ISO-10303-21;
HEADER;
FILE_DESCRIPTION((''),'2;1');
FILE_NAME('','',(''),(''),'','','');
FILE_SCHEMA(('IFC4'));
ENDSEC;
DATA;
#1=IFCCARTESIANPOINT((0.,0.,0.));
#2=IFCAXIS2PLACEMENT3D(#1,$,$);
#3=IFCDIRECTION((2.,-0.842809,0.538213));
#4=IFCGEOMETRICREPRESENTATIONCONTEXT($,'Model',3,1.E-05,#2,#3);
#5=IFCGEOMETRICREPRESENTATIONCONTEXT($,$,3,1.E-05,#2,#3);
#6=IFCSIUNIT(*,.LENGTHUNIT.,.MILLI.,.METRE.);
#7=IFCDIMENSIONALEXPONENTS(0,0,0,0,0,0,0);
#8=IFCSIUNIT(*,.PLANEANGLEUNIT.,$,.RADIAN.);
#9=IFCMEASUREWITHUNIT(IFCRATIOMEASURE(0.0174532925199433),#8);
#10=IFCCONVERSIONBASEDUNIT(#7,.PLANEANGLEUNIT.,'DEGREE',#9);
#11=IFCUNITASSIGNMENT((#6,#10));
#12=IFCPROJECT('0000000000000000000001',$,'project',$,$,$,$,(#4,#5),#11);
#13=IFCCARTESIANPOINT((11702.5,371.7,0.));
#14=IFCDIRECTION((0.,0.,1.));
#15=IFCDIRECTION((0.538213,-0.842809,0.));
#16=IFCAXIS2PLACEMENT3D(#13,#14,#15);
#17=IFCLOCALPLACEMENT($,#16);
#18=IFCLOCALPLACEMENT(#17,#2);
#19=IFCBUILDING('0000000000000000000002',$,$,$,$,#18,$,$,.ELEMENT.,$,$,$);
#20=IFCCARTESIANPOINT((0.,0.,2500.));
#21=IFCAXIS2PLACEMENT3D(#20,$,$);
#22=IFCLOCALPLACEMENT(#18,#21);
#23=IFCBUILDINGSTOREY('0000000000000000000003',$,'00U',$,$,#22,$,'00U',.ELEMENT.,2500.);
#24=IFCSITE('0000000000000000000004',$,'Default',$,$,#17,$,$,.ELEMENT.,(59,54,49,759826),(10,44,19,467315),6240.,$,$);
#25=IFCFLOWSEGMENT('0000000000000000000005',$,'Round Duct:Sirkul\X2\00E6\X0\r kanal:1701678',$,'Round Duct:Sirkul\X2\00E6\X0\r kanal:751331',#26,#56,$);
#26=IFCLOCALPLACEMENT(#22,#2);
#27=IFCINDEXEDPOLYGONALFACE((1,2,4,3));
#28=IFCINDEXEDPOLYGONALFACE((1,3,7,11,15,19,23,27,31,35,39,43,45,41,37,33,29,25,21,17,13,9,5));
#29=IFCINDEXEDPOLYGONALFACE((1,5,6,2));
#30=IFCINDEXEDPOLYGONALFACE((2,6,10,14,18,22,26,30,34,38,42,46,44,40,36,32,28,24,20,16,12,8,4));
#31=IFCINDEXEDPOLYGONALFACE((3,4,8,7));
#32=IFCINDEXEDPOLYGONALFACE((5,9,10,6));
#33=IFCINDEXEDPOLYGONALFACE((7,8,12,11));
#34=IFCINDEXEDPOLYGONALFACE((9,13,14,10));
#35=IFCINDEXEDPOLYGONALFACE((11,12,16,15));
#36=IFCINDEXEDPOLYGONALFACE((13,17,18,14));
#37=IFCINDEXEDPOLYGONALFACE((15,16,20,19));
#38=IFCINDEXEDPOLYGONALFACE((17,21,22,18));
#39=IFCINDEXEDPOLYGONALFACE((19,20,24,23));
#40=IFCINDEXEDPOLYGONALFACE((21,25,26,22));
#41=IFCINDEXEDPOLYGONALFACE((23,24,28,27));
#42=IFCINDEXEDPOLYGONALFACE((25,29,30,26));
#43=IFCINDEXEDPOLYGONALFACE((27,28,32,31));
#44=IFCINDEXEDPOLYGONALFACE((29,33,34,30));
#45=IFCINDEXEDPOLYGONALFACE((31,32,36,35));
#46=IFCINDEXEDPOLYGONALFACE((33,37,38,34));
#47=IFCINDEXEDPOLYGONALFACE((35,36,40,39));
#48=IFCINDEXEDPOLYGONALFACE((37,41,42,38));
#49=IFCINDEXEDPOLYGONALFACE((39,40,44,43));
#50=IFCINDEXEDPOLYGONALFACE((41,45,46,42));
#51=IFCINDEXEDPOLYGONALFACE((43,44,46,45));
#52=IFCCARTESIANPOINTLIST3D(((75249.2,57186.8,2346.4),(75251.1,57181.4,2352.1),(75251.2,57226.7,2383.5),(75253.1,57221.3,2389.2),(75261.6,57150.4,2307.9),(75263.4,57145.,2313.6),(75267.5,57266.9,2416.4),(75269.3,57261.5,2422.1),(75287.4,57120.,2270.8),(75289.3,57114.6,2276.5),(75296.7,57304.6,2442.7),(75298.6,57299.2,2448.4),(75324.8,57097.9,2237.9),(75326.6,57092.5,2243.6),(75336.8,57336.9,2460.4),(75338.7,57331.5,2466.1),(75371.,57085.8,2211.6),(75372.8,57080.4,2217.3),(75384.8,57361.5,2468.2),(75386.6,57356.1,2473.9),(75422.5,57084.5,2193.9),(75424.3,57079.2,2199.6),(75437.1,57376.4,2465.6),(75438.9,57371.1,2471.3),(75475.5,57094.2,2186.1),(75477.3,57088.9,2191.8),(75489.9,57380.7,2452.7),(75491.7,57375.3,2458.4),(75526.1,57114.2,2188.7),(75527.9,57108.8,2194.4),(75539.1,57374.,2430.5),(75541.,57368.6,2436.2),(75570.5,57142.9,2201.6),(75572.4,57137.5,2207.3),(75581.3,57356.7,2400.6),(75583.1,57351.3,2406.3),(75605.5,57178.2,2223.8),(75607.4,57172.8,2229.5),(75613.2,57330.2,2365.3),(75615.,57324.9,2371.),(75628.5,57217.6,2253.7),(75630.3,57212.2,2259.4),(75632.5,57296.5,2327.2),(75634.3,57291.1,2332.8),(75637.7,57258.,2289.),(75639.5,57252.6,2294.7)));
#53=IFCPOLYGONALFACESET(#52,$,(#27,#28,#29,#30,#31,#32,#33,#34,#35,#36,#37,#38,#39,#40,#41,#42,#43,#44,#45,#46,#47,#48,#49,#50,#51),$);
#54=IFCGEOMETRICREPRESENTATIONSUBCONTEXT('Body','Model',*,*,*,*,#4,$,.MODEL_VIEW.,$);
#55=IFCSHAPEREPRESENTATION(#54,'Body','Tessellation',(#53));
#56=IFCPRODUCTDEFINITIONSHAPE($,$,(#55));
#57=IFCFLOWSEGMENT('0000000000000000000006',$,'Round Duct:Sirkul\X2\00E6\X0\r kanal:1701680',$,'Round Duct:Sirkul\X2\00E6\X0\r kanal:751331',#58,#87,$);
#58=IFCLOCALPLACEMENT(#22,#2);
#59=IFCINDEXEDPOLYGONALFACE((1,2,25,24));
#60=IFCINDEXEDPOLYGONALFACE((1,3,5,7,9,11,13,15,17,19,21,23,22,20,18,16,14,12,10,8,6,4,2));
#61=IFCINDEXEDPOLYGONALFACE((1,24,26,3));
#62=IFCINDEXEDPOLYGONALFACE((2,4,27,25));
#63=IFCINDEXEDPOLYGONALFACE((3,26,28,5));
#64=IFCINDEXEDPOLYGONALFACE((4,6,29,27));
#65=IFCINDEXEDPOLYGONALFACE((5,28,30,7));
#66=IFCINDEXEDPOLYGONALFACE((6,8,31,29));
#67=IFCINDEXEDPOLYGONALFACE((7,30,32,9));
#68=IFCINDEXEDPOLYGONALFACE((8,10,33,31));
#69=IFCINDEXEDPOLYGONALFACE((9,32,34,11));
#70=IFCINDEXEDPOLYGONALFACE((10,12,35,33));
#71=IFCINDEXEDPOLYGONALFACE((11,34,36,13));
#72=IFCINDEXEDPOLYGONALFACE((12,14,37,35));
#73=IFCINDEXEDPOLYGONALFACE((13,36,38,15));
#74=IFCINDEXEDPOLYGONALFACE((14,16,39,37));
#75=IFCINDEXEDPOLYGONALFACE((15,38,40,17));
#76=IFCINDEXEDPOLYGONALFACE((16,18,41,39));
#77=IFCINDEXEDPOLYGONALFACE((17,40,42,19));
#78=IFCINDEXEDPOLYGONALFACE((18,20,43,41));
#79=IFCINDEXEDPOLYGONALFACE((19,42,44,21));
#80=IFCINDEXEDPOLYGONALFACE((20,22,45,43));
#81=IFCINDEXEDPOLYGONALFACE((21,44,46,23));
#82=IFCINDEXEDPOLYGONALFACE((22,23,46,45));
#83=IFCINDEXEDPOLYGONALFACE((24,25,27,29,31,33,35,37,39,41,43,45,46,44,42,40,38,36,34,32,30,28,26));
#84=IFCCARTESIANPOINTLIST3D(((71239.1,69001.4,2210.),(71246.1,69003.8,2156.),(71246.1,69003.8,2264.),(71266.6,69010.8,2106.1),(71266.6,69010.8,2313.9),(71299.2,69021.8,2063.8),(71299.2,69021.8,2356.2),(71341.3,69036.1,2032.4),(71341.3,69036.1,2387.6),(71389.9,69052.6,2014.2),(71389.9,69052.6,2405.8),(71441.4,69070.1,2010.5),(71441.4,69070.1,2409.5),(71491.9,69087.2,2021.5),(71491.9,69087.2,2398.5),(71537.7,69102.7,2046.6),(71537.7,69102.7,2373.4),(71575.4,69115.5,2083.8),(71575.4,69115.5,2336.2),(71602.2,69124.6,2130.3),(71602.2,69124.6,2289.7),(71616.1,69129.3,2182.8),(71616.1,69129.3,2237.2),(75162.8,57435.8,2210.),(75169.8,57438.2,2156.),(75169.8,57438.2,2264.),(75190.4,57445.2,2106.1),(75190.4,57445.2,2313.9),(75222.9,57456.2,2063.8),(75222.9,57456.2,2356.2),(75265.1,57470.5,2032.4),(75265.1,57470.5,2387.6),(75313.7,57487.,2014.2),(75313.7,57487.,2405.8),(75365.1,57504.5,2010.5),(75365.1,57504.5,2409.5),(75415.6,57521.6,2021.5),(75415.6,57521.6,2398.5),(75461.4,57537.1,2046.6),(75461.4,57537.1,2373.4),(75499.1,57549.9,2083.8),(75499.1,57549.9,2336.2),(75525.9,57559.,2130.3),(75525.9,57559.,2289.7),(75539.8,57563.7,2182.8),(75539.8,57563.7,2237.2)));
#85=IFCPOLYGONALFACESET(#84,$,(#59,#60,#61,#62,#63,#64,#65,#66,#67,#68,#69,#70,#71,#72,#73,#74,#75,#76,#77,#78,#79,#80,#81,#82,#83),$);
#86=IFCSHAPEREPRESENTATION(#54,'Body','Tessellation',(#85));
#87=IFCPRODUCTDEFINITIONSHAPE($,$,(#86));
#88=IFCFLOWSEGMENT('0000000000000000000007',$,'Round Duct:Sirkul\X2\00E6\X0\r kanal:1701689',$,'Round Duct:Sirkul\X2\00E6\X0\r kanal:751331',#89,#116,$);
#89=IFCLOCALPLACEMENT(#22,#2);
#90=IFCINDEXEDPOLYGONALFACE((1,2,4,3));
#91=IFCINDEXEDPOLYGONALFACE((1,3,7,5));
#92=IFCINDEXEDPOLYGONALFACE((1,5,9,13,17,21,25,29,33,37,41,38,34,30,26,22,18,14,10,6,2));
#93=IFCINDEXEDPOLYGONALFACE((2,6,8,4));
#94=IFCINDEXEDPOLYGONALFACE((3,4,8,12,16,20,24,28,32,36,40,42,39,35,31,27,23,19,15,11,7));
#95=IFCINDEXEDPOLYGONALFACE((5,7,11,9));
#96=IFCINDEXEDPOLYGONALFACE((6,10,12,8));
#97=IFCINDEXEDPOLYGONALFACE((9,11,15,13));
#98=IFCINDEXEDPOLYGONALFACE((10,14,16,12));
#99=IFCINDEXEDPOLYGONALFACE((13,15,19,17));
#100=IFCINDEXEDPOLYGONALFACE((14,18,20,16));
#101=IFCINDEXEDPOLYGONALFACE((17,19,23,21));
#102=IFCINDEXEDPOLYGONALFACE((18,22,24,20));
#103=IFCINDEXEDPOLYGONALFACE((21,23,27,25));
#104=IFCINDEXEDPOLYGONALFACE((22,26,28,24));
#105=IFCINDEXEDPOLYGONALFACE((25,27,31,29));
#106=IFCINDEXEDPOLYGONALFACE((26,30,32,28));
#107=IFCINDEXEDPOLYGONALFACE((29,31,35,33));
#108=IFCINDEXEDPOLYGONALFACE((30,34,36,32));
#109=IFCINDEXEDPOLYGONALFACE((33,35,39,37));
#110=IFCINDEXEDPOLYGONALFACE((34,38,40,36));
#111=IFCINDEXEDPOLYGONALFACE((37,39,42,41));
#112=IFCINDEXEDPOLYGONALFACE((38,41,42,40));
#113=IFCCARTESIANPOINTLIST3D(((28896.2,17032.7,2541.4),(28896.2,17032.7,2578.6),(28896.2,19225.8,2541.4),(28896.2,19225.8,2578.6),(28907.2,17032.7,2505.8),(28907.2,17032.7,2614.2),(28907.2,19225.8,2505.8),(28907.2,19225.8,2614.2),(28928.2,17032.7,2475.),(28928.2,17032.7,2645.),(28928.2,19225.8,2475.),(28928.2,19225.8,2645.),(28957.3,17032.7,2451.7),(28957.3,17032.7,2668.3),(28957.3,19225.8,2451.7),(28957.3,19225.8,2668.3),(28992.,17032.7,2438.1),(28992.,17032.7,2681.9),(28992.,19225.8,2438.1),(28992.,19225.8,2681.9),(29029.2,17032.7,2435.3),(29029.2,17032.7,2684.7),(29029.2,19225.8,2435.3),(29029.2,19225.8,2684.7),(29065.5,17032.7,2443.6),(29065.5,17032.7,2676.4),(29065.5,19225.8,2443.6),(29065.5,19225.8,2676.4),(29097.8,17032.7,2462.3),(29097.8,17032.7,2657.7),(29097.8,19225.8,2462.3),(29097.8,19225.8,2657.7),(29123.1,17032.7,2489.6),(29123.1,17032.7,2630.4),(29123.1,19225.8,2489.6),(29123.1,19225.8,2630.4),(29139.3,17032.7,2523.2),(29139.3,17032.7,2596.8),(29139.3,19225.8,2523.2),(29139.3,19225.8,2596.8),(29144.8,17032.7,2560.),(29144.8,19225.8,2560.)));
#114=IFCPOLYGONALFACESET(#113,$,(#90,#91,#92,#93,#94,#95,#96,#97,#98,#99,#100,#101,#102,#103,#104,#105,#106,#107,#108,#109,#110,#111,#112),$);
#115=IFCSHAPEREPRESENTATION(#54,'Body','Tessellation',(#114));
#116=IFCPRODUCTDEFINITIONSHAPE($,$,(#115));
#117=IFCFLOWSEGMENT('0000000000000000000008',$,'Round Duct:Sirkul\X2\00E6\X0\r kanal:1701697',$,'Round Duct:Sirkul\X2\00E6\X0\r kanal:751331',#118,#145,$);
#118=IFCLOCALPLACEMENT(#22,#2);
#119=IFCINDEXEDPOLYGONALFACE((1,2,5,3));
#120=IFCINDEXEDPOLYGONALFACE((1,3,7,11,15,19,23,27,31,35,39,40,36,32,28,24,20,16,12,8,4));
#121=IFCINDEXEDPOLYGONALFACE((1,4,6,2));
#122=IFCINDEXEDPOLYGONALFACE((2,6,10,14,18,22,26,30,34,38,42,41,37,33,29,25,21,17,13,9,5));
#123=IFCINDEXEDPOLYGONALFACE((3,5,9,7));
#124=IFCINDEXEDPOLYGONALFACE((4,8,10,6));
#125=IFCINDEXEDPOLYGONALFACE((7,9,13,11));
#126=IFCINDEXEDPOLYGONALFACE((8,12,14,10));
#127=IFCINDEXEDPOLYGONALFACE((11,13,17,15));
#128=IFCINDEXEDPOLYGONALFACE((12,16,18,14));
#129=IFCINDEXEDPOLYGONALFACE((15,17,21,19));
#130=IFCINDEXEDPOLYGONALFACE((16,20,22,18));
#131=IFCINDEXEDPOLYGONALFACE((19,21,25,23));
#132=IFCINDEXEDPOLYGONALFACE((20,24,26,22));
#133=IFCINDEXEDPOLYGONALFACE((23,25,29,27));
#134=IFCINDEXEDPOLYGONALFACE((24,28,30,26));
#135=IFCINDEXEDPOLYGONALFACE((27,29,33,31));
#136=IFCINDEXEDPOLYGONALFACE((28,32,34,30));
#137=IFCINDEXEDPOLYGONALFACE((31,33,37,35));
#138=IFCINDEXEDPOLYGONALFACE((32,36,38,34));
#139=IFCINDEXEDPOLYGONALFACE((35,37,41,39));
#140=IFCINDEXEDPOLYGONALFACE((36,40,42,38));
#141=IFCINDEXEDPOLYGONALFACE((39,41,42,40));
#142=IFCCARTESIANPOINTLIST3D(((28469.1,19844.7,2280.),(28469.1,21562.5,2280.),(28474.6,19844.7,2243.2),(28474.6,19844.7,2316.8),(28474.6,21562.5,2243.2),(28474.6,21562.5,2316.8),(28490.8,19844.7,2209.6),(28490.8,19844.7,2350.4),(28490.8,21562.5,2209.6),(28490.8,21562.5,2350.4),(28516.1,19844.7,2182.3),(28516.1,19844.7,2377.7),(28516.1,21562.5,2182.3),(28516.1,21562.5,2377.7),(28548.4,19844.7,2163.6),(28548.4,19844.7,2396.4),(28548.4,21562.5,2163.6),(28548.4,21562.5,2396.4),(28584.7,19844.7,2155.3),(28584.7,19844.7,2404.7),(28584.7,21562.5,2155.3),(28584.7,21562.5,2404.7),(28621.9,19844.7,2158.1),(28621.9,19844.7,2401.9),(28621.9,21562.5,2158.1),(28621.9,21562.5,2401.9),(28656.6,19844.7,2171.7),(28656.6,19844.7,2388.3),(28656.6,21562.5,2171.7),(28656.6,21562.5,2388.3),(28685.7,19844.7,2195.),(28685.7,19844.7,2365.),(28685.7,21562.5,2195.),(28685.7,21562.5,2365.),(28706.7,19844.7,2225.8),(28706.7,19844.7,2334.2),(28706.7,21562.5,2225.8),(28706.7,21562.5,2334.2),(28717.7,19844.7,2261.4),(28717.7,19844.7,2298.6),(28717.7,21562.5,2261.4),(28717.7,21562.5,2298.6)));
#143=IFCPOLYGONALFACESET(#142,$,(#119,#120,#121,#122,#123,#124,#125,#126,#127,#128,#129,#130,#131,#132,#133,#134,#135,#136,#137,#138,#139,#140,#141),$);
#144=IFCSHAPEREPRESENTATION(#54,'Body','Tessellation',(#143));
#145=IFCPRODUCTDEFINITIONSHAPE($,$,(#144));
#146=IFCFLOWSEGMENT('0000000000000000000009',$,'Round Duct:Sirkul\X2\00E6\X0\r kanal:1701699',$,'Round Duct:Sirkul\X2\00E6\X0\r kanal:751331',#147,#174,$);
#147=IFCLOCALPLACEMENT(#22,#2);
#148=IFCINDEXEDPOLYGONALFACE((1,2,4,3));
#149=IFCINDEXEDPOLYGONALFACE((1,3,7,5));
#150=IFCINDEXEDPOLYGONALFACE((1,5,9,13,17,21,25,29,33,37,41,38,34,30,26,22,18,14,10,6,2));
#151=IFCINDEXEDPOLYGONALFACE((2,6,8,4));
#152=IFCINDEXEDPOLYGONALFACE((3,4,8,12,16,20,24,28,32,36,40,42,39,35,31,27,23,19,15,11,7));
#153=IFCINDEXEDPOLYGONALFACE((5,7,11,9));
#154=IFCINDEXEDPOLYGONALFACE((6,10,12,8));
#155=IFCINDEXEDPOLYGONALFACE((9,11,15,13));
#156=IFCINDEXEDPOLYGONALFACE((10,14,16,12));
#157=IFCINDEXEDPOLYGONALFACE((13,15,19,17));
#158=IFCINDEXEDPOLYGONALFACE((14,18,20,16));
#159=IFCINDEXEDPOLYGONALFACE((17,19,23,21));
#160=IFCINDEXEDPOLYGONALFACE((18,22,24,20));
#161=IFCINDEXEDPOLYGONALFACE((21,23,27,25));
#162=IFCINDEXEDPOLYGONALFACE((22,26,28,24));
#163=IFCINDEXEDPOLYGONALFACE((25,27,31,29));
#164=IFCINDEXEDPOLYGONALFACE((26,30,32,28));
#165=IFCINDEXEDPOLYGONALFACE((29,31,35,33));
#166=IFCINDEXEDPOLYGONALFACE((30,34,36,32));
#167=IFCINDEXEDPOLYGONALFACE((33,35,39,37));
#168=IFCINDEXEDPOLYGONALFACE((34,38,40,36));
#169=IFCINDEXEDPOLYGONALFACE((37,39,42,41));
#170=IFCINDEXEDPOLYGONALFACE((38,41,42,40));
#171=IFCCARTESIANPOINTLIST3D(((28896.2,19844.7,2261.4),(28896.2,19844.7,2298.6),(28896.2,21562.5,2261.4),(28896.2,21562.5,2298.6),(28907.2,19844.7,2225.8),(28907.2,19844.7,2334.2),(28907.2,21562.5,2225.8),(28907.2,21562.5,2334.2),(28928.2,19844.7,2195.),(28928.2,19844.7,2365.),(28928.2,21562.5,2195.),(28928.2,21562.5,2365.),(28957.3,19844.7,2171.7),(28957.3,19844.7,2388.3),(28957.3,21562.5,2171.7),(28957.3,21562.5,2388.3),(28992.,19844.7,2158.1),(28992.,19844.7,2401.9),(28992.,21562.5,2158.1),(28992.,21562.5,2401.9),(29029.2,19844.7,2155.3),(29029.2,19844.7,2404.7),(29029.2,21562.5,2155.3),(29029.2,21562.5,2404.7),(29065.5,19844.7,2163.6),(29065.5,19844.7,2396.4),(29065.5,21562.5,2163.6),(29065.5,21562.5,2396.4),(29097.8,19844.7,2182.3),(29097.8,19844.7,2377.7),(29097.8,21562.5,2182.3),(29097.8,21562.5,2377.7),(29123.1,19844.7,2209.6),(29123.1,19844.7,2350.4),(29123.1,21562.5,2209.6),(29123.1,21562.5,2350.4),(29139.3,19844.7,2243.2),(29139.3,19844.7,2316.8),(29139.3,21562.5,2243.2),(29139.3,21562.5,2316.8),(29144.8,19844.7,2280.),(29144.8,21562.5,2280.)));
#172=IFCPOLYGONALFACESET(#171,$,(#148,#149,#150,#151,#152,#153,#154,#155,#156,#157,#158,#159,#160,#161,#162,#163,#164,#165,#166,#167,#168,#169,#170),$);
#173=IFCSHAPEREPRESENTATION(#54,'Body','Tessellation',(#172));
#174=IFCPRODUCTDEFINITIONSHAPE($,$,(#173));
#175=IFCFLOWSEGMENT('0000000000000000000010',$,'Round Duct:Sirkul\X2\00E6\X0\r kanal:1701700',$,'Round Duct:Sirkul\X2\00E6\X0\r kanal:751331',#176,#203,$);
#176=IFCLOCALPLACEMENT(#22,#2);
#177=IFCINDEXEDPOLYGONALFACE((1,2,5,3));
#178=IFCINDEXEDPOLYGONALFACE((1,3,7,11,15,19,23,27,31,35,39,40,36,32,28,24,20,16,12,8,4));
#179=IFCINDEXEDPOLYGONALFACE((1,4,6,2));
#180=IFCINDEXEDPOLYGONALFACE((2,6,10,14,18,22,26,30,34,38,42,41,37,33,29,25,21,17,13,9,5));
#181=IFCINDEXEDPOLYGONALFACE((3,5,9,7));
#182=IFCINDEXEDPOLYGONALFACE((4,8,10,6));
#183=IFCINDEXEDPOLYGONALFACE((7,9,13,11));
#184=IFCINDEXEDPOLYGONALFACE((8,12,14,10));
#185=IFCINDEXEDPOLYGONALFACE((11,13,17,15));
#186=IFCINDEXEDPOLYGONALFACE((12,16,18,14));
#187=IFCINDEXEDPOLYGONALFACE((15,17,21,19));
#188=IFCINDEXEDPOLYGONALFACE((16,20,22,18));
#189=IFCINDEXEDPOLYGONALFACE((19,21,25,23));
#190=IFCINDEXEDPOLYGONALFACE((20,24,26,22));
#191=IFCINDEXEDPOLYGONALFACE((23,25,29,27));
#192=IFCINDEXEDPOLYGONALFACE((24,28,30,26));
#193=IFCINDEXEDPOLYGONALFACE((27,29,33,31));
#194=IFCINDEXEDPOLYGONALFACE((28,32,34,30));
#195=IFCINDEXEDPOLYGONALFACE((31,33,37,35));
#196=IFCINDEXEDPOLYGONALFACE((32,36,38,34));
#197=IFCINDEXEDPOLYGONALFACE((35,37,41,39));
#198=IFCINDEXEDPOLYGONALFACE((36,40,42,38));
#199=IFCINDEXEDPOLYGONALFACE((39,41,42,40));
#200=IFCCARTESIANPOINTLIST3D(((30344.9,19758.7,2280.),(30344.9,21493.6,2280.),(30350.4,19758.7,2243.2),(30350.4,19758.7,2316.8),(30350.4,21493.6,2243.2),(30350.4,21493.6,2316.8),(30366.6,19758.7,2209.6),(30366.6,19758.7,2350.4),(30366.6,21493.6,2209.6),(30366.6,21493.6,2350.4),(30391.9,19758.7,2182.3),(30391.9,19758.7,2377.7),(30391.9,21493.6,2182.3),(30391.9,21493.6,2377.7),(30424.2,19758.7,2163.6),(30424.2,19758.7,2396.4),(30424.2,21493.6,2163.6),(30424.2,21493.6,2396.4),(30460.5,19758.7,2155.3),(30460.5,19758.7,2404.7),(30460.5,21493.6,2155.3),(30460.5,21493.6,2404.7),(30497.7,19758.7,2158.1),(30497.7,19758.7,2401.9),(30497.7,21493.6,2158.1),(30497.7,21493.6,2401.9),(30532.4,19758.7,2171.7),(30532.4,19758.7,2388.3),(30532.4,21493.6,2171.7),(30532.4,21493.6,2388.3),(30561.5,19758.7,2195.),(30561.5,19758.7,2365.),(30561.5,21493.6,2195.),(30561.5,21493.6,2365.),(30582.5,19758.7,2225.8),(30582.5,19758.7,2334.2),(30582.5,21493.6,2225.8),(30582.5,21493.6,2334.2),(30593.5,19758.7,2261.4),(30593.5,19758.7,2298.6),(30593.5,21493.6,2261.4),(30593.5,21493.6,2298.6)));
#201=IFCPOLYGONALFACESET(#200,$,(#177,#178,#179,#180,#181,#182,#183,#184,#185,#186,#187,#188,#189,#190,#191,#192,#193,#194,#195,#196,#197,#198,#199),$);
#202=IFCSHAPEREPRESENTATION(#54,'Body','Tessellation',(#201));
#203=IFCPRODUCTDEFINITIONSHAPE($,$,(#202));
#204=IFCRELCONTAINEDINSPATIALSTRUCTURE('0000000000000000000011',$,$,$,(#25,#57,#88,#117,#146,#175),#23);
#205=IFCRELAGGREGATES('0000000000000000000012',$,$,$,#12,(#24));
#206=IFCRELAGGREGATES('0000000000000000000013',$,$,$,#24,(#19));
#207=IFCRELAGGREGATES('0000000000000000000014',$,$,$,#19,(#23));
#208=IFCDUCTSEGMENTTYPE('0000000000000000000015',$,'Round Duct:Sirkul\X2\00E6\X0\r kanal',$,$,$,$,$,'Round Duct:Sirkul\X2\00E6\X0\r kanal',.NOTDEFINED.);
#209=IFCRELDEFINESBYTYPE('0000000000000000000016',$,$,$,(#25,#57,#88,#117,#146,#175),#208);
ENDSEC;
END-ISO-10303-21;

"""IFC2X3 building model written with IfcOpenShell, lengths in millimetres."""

from ifc_helpers import new_model, entity, si_unit, converted_unit, direction, frame, frame_2d, origin, origin_2d_with_axis, place, context, subcontext, project, spatial, circle, extrude, type_object, element, save


model = new_model("IFC2X3")

# Units and contexts
model_context = context("Model", 3, precision=1e-05, world=origin(), true_north=direction((2.0, -0.842809, 0.538213)))
context_of_model = context(None, 3, precision=1e-05, world=origin(), true_north=direction((2.0, -0.842809, 0.538213)))
body_context = subcontext(model_context, "Body", "Model", "MODEL_VIEW")
ifc_project = project(units=[si_unit("LENGTHUNIT", "METRE", prefix="MILLI"), converted_unit("PLANEANGLEUNIT", "DEGREE", entity("IfcRatioMeasure", 0.0174532925199433), si_unit("PLANEANGLEUNIT", "RADIAN"), dimensions=[0, 0, 0, 0, 0, 0, 0])], contexts=[model_context, context_of_model])

# Site, building, storey
site_placement = place(None, frame((11702.5, 371.7, 0.0), z_axis=(0.0, 0.0, 1.0), x_axis=(0.538213, -0.842809, 0.0)))
site = spatial("IfcSite", under=ifc_project, at=site_placement, Name="Default", CompositionType="ELEMENT", RefLatitude=(59, 54, 49, 759826), RefLongitude=(10, 44, 19, 467315), RefElevation=6240.0)
building_placement = place(site_placement, origin())
building = spatial("IfcBuilding", under=site, at=building_placement, CompositionType="ELEMENT")
storey_placement = place(building_placement, frame((0.0, 0.0, 2500.0)))
storey = spatial("IfcBuildingStorey", under=building, at=storey_placement, Name="00U", LongName="00U", CompositionType="ELEMENT", Elevation=2500.0)

# Flow segments
duct_segment_type = type_object("IfcDuctSegmentType", Name="Round Duct:Sirkulær kanal", ElementType="Round Duct:Sirkulær kanal", PredefinedType="NOTDEFINED")
flow_segment_1_placement = place(storey_placement, origin())
element("IfcFlowSegment", 1, at=flow_segment_1_placement, inside=storey, type_object=duct_segment_type, Name="Round Duct:Sirkulær kanal:1701678", ObjectType="Round Duct:Sirkulær kanal:751331", context=body_context, shape_type="SweptSolid", body=[
    extrude(circle(Radius=200.0, at=frame_2d((0.0, 0.0), x_axis=(1.0, 0.0))), frame((75443.1, 57232.2, 2327.2), z_axis=(0.227175, -0.66962, 0.707107), x_axis=(0.946986, 0.321274, 0.0)), (0.0, 0.0, 1.0), 8.0),
])
flow_segment_2_placement = place(storey_placement, origin())
element("IfcFlowSegment", 2, at=flow_segment_2_placement, inside=storey, type_object=duct_segment_type, Name="Round Duct:Sirkulær kanal:1701680", ObjectType="Round Duct:Sirkulær kanal:751331", context=body_context, shape_type="SweptSolid", body=[
    extrude(circle(Radius=200.0, at=frame_2d((0.0, 0.0), x_axis=(1.0, 0.0))), frame((75352.2, 57500.1, 2210.0), z_axis=(-0.321274, 0.946986, 0.0), x_axis=(-0.946986, -0.321274, 0.0)), (0.0, 0.0, 1.0), 12213.1),
])
flow_segment_3_placement = place(storey_placement, origin())
element("IfcFlowSegment", 3, at=flow_segment_3_placement, inside=storey, type_object=duct_segment_type, Name="Round Duct:Sirkulær kanal:1701689", ObjectType="Round Duct:Sirkulær kanal:751331", context=body_context, shape_type="SweptSolid", body=[
    extrude(circle(Radius=125.0, at=origin_2d_with_axis()), frame((29019.8, 17032.7, 2560.0), z_axis=(0.0, 1.0, 0.0), x_axis=(1.0, 0.0, 0.0)), (0.0, 0.0, 1.0), 2193.1),
])
flow_segment_4_placement = place(storey_placement, origin())
element("IfcFlowSegment", 4, at=flow_segment_4_placement, inside=storey, type_object=duct_segment_type, Name="Round Duct:Sirkulær kanal:1701697", ObjectType="Round Duct:Sirkulær kanal:751331", context=body_context, shape_type="SweptSolid", body=[
    extrude(circle(Radius=125.0, at=frame_2d((0.0, 0.0), x_axis=(1.0, 0.0))), frame((28594.1, 19844.7, 2280.0), z_axis=(0.0, 1.0, 0.0), x_axis=(-1.0, 0.0, 0.0)), (0.0, 0.0, 1.0), 1717.8),
])
flow_segment_5_placement = place(storey_placement, origin())
element("IfcFlowSegment", 5, at=flow_segment_5_placement, inside=storey, type_object=duct_segment_type, Name="Round Duct:Sirkulær kanal:1701699", ObjectType="Round Duct:Sirkulær kanal:751331", context=body_context, shape_type="SweptSolid", body=[
    extrude(circle(Radius=125.0, at=origin_2d_with_axis()), frame((29019.8, 19844.7, 2280.0), z_axis=(0.0, 1.0, 0.0), x_axis=(1.0, 0.0, 0.0)), (0.0, 0.0, 1.0), 1717.8),
])
flow_segment_6_placement = place(storey_placement, origin())
element("IfcFlowSegment", 6, at=flow_segment_6_placement, inside=storey, type_object=duct_segment_type, Name="Round Duct:Sirkulær kanal:1701700", ObjectType="Round Duct:Sirkulær kanal:751331", context=body_context, shape_type="SweptSolid", body=[
    extrude(circle(Radius=125.0, at=origin_2d_with_axis()), frame((30469.9, 19758.7, 2280.0), z_axis=(0.0, 1.0, 0.0), x_axis=(-1.0, 0.0, 0.0)), (0.0, 0.0, 1.0), 1734.9),
])

save(model, "model.ifc")
